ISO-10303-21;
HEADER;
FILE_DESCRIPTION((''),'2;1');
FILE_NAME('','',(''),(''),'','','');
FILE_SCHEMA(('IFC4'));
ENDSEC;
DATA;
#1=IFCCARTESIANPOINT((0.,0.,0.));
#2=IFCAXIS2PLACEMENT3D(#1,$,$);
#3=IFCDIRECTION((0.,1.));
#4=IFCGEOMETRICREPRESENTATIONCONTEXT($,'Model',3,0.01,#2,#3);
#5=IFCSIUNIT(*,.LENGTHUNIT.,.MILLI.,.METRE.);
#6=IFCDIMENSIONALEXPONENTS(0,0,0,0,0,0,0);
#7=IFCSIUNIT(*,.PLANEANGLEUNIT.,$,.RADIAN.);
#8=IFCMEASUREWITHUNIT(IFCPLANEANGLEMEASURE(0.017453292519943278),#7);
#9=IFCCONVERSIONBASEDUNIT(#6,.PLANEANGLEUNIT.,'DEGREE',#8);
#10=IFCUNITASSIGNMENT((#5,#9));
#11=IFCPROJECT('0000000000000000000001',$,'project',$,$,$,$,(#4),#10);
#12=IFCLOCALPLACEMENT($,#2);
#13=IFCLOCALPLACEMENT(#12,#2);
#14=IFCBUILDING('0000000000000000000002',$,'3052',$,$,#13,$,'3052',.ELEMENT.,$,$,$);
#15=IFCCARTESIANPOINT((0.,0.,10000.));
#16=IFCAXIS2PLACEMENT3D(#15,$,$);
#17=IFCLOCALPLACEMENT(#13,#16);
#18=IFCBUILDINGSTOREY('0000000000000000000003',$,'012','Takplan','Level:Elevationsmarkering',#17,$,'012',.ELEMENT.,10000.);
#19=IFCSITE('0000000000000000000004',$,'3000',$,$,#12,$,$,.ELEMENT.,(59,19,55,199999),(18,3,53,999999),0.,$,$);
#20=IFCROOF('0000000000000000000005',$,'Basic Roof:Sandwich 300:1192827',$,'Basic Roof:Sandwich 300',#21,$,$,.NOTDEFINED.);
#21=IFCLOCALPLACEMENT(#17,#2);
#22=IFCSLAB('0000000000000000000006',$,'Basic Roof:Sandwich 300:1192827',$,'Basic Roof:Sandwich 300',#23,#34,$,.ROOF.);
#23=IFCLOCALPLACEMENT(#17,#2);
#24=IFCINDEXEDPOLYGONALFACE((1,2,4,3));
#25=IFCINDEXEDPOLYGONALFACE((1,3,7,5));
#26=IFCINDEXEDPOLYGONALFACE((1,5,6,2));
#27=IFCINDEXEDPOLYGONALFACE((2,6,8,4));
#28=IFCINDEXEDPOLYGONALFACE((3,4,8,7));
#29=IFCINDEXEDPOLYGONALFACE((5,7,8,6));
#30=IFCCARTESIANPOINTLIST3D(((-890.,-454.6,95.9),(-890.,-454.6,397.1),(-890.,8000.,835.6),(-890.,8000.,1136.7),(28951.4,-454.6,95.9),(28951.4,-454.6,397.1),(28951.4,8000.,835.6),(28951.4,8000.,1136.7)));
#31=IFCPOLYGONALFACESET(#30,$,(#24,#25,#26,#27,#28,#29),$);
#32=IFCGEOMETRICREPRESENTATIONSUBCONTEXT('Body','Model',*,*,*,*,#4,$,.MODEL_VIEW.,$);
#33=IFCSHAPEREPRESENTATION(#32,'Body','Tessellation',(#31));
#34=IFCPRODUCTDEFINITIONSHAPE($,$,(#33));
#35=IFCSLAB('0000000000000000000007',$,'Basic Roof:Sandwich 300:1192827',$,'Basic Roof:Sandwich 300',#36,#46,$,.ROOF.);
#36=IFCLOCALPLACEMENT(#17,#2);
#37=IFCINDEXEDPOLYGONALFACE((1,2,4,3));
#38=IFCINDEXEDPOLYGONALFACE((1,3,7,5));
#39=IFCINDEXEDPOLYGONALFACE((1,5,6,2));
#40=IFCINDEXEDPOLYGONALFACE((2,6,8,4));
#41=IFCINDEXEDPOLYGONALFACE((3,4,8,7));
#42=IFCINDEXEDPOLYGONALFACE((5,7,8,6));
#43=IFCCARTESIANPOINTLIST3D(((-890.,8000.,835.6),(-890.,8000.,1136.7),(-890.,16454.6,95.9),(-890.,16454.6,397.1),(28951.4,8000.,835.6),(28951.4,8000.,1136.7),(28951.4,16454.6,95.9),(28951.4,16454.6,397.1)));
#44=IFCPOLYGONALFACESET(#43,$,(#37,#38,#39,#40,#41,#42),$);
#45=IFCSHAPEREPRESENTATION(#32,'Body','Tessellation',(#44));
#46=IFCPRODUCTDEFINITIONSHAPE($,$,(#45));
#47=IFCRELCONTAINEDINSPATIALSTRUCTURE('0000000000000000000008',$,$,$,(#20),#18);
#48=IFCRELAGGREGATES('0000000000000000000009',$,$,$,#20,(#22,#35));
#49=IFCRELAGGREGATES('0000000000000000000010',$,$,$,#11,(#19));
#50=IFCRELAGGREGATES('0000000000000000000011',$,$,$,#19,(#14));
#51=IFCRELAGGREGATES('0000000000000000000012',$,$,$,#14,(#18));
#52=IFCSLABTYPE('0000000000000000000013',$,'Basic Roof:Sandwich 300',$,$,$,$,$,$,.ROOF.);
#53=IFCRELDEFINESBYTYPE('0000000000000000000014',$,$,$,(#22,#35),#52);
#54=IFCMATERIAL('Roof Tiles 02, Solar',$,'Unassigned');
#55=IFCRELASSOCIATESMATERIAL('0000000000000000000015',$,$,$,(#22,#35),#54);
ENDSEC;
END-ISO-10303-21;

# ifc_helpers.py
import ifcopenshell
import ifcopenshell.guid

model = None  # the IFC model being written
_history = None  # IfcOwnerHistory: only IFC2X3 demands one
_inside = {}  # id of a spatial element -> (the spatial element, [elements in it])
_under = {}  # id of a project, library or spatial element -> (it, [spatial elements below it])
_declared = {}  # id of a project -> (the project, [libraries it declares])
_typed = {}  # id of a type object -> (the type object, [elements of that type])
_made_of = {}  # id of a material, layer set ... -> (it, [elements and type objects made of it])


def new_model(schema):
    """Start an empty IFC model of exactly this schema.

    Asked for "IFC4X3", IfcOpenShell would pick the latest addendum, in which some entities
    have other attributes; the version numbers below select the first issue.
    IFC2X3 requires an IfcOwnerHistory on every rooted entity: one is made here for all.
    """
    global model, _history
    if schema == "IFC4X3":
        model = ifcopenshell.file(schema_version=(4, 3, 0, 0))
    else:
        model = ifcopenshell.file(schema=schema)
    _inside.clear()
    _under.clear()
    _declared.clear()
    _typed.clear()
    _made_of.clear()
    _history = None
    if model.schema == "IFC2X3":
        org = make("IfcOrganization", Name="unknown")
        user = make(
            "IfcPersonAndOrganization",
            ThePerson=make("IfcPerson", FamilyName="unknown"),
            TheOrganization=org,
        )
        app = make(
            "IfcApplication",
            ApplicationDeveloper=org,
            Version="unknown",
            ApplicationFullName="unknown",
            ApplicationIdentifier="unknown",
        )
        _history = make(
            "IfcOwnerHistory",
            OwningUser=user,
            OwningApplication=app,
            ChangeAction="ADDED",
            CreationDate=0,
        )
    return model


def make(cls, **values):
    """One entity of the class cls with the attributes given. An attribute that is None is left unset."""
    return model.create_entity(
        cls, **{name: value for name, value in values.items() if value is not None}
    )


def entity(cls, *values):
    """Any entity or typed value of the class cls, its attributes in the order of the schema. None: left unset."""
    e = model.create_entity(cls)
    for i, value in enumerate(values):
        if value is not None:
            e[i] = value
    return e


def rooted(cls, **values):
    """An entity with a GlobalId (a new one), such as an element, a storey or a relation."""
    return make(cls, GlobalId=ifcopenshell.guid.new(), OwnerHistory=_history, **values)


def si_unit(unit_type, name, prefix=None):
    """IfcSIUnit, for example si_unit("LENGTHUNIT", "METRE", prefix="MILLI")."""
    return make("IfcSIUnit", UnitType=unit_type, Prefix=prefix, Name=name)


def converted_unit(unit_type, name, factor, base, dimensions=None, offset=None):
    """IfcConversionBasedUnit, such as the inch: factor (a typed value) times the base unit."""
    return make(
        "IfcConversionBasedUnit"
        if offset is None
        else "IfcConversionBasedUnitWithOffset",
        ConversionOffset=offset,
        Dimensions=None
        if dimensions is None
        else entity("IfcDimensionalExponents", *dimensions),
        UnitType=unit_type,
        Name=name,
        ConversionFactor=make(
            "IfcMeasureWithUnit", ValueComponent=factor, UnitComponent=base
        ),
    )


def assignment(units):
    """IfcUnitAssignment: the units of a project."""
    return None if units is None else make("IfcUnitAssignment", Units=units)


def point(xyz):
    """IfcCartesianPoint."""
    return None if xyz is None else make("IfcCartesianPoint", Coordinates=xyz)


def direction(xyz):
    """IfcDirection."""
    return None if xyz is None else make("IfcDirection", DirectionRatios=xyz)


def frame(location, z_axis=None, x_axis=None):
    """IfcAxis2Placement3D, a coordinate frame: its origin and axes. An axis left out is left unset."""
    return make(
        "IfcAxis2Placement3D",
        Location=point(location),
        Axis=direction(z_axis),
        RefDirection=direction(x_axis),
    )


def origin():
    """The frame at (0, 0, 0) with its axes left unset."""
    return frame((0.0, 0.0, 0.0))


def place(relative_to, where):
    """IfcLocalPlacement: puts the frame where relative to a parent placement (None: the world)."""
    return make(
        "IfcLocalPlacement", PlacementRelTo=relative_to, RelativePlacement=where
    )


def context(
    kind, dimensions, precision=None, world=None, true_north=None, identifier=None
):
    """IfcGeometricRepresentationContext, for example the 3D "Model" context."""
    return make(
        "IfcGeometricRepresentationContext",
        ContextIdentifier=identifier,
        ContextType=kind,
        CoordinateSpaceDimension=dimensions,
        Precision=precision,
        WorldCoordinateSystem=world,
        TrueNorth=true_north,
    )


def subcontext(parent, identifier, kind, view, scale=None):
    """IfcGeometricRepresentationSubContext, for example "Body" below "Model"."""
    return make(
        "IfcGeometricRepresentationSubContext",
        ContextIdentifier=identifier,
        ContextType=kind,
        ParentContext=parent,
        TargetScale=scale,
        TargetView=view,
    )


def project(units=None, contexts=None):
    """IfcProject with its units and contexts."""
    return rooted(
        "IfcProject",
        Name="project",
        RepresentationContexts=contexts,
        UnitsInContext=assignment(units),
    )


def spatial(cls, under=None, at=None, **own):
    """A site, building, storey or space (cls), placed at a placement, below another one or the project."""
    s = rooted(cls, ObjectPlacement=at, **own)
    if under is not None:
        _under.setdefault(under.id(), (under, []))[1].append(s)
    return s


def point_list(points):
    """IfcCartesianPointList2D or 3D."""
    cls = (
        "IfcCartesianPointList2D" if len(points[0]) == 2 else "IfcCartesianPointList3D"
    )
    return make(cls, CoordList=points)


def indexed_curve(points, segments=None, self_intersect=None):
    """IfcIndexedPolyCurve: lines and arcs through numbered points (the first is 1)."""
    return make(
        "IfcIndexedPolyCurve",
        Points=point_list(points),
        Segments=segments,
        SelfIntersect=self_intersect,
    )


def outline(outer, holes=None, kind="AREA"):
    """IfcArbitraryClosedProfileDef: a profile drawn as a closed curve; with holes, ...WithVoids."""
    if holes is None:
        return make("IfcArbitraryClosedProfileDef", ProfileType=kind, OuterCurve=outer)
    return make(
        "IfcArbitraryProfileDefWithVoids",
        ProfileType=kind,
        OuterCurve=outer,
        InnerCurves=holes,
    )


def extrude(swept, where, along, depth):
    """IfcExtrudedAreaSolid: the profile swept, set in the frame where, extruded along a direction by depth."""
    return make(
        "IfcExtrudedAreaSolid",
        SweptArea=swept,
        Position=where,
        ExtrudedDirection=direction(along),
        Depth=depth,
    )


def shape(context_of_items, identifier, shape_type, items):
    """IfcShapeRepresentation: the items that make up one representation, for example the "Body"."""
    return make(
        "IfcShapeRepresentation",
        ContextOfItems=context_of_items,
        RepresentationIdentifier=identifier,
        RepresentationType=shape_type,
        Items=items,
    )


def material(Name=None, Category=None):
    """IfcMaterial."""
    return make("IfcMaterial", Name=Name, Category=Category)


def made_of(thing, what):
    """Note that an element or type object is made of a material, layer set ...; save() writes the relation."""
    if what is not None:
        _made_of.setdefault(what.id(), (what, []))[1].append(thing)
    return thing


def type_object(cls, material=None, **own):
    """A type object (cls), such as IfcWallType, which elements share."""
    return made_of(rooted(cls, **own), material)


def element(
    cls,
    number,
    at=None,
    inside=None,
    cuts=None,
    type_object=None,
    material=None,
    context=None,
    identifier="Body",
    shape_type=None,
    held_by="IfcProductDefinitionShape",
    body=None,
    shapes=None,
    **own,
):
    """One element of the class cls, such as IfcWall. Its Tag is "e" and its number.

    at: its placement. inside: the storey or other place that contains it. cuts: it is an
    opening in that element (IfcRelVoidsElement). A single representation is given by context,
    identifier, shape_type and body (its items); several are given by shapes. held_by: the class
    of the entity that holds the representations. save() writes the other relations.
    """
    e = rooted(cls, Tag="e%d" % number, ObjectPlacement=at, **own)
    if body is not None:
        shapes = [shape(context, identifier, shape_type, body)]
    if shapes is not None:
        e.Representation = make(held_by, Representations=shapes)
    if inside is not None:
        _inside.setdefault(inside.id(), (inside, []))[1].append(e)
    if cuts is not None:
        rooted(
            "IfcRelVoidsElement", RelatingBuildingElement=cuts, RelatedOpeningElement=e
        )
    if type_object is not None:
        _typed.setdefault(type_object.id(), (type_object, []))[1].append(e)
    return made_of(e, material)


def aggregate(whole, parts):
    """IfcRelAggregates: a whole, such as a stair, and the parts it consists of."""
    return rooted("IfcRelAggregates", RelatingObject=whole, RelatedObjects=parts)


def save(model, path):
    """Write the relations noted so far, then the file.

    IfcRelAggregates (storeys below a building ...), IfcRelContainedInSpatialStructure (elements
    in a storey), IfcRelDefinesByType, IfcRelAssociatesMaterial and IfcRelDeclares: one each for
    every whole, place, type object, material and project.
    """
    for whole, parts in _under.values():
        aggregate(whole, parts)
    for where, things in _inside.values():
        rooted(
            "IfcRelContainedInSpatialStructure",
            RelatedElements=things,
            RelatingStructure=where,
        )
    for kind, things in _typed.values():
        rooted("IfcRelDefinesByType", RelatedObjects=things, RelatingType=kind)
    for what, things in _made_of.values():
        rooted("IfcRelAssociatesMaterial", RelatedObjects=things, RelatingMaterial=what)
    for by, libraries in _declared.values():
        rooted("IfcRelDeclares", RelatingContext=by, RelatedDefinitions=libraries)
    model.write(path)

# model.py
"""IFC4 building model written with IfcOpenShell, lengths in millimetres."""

from ifc_helpers import new_model, entity, si_unit, converted_unit, direction, frame, origin, place, context, subcontext, project, spatial, indexed_curve, outline, extrude, material, type_object, element, aggregate, save


model = new_model("IFC4")

# Units and contexts
model_context = context("Model", 3, precision=0.01, world=origin(), true_north=direction((0.0, 1.0)))
body_context = subcontext(model_context, "Body", "Model", "MODEL_VIEW")
ifc_project = project(units=[si_unit("LENGTHUNIT", "METRE", prefix="MILLI"), converted_unit("PLANEANGLEUNIT", "DEGREE", entity("IfcPlaneAngleMeasure", 0.017453292519943278), si_unit("PLANEANGLEUNIT", "RADIAN"), dimensions=[0, 0, 0, 0, 0, 0, 0])], contexts=[model_context])

# Site, building, storey
site_placement = place(None, origin())
site = spatial("IfcSite", under=ifc_project, at=site_placement, Name="3000", CompositionType="ELEMENT", RefLatitude=(59, 19, 55, 199999), RefLongitude=(18, 3, 53, 999999), RefElevation=0.0)
building_placement = place(site_placement, origin())
building = spatial("IfcBuilding", under=site, at=building_placement, Name="3052", LongName="3052", CompositionType="ELEMENT")
storey_placement = place(building_placement, frame((0.0, 0.0, 10000.0)))
storey = spatial("IfcBuildingStorey", under=building, at=storey_placement, Name="012", Description="Takplan", ObjectType="Level:Elevationsmarkering", LongName="012", CompositionType="ELEMENT", Elevation=10000.0)

# Roof, slabs
roof_placement = place(storey_placement, frame((-890.0, -454.6, 95.9)))
roof = element("IfcRoof", 1, at=roof_placement, inside=storey, Name="Basic Roof:Sandwich 300:1192827", ObjectType="Basic Roof:Sandwich 300", PredefinedType="NOTDEFINED")
ifc_material_1 = material(Name="Roof Tiles 02, Solar", Category="Unassigned")
slab_type = type_object("IfcSlabType", Name="Basic Roof:Sandwich 300", PredefinedType="ROOF")
slab_1_placement = place(roof_placement, origin())
slab_1 = element("IfcSlab", 2, at=slab_1_placement, type_object=slab_type, material=ifc_material_1, Name="Basic Roof:Sandwich 300:1192827", ObjectType="Basic Roof:Sandwich 300", PredefinedType="ROOF", context=body_context, shape_type="SweptSolid", body=[
    extrude(outline(indexed_curve([(-14920.7, -4243.5), (14920.7, -4243.5), (14920.7, 4243.5), (-14920.7, 4243.5), (-14920.7, -4243.5)], self_intersect=False)), frame((14920.7, 4227.3, 369.8), z_axis=(0.0, -0.087156, 0.996195), x_axis=(1.0, 0.0, 0.0)), (0.0, 0.087156, 0.996195), 301.1),
])
slab_2_placement = place(roof_placement, origin())
slab_2 = element("IfcSlab", 3, at=slab_2_placement, type_object=slab_type, material=ifc_material_1, Name="Basic Roof:Sandwich 300:1192827", ObjectType="Basic Roof:Sandwich 300", PredefinedType="ROOF", context=body_context, shape_type="SweptSolid", body=[
    extrude(outline(indexed_curve([(-14920.7, -4243.5), (14920.7, -4243.5), (14920.7, 4243.5), (-14920.7, 4243.5), (-14920.7, -4243.5)], self_intersect=False)), frame((14920.7, 12681.9, 369.8), z_axis=(0.0, 0.087156, 0.996195), x_axis=(1.0, 0.0, 0.0)), (0.0, -0.087156, 0.996195), 301.1),
])
aggregate(roof, [slab_1, slab_2])

save(model, "model.ifc")
